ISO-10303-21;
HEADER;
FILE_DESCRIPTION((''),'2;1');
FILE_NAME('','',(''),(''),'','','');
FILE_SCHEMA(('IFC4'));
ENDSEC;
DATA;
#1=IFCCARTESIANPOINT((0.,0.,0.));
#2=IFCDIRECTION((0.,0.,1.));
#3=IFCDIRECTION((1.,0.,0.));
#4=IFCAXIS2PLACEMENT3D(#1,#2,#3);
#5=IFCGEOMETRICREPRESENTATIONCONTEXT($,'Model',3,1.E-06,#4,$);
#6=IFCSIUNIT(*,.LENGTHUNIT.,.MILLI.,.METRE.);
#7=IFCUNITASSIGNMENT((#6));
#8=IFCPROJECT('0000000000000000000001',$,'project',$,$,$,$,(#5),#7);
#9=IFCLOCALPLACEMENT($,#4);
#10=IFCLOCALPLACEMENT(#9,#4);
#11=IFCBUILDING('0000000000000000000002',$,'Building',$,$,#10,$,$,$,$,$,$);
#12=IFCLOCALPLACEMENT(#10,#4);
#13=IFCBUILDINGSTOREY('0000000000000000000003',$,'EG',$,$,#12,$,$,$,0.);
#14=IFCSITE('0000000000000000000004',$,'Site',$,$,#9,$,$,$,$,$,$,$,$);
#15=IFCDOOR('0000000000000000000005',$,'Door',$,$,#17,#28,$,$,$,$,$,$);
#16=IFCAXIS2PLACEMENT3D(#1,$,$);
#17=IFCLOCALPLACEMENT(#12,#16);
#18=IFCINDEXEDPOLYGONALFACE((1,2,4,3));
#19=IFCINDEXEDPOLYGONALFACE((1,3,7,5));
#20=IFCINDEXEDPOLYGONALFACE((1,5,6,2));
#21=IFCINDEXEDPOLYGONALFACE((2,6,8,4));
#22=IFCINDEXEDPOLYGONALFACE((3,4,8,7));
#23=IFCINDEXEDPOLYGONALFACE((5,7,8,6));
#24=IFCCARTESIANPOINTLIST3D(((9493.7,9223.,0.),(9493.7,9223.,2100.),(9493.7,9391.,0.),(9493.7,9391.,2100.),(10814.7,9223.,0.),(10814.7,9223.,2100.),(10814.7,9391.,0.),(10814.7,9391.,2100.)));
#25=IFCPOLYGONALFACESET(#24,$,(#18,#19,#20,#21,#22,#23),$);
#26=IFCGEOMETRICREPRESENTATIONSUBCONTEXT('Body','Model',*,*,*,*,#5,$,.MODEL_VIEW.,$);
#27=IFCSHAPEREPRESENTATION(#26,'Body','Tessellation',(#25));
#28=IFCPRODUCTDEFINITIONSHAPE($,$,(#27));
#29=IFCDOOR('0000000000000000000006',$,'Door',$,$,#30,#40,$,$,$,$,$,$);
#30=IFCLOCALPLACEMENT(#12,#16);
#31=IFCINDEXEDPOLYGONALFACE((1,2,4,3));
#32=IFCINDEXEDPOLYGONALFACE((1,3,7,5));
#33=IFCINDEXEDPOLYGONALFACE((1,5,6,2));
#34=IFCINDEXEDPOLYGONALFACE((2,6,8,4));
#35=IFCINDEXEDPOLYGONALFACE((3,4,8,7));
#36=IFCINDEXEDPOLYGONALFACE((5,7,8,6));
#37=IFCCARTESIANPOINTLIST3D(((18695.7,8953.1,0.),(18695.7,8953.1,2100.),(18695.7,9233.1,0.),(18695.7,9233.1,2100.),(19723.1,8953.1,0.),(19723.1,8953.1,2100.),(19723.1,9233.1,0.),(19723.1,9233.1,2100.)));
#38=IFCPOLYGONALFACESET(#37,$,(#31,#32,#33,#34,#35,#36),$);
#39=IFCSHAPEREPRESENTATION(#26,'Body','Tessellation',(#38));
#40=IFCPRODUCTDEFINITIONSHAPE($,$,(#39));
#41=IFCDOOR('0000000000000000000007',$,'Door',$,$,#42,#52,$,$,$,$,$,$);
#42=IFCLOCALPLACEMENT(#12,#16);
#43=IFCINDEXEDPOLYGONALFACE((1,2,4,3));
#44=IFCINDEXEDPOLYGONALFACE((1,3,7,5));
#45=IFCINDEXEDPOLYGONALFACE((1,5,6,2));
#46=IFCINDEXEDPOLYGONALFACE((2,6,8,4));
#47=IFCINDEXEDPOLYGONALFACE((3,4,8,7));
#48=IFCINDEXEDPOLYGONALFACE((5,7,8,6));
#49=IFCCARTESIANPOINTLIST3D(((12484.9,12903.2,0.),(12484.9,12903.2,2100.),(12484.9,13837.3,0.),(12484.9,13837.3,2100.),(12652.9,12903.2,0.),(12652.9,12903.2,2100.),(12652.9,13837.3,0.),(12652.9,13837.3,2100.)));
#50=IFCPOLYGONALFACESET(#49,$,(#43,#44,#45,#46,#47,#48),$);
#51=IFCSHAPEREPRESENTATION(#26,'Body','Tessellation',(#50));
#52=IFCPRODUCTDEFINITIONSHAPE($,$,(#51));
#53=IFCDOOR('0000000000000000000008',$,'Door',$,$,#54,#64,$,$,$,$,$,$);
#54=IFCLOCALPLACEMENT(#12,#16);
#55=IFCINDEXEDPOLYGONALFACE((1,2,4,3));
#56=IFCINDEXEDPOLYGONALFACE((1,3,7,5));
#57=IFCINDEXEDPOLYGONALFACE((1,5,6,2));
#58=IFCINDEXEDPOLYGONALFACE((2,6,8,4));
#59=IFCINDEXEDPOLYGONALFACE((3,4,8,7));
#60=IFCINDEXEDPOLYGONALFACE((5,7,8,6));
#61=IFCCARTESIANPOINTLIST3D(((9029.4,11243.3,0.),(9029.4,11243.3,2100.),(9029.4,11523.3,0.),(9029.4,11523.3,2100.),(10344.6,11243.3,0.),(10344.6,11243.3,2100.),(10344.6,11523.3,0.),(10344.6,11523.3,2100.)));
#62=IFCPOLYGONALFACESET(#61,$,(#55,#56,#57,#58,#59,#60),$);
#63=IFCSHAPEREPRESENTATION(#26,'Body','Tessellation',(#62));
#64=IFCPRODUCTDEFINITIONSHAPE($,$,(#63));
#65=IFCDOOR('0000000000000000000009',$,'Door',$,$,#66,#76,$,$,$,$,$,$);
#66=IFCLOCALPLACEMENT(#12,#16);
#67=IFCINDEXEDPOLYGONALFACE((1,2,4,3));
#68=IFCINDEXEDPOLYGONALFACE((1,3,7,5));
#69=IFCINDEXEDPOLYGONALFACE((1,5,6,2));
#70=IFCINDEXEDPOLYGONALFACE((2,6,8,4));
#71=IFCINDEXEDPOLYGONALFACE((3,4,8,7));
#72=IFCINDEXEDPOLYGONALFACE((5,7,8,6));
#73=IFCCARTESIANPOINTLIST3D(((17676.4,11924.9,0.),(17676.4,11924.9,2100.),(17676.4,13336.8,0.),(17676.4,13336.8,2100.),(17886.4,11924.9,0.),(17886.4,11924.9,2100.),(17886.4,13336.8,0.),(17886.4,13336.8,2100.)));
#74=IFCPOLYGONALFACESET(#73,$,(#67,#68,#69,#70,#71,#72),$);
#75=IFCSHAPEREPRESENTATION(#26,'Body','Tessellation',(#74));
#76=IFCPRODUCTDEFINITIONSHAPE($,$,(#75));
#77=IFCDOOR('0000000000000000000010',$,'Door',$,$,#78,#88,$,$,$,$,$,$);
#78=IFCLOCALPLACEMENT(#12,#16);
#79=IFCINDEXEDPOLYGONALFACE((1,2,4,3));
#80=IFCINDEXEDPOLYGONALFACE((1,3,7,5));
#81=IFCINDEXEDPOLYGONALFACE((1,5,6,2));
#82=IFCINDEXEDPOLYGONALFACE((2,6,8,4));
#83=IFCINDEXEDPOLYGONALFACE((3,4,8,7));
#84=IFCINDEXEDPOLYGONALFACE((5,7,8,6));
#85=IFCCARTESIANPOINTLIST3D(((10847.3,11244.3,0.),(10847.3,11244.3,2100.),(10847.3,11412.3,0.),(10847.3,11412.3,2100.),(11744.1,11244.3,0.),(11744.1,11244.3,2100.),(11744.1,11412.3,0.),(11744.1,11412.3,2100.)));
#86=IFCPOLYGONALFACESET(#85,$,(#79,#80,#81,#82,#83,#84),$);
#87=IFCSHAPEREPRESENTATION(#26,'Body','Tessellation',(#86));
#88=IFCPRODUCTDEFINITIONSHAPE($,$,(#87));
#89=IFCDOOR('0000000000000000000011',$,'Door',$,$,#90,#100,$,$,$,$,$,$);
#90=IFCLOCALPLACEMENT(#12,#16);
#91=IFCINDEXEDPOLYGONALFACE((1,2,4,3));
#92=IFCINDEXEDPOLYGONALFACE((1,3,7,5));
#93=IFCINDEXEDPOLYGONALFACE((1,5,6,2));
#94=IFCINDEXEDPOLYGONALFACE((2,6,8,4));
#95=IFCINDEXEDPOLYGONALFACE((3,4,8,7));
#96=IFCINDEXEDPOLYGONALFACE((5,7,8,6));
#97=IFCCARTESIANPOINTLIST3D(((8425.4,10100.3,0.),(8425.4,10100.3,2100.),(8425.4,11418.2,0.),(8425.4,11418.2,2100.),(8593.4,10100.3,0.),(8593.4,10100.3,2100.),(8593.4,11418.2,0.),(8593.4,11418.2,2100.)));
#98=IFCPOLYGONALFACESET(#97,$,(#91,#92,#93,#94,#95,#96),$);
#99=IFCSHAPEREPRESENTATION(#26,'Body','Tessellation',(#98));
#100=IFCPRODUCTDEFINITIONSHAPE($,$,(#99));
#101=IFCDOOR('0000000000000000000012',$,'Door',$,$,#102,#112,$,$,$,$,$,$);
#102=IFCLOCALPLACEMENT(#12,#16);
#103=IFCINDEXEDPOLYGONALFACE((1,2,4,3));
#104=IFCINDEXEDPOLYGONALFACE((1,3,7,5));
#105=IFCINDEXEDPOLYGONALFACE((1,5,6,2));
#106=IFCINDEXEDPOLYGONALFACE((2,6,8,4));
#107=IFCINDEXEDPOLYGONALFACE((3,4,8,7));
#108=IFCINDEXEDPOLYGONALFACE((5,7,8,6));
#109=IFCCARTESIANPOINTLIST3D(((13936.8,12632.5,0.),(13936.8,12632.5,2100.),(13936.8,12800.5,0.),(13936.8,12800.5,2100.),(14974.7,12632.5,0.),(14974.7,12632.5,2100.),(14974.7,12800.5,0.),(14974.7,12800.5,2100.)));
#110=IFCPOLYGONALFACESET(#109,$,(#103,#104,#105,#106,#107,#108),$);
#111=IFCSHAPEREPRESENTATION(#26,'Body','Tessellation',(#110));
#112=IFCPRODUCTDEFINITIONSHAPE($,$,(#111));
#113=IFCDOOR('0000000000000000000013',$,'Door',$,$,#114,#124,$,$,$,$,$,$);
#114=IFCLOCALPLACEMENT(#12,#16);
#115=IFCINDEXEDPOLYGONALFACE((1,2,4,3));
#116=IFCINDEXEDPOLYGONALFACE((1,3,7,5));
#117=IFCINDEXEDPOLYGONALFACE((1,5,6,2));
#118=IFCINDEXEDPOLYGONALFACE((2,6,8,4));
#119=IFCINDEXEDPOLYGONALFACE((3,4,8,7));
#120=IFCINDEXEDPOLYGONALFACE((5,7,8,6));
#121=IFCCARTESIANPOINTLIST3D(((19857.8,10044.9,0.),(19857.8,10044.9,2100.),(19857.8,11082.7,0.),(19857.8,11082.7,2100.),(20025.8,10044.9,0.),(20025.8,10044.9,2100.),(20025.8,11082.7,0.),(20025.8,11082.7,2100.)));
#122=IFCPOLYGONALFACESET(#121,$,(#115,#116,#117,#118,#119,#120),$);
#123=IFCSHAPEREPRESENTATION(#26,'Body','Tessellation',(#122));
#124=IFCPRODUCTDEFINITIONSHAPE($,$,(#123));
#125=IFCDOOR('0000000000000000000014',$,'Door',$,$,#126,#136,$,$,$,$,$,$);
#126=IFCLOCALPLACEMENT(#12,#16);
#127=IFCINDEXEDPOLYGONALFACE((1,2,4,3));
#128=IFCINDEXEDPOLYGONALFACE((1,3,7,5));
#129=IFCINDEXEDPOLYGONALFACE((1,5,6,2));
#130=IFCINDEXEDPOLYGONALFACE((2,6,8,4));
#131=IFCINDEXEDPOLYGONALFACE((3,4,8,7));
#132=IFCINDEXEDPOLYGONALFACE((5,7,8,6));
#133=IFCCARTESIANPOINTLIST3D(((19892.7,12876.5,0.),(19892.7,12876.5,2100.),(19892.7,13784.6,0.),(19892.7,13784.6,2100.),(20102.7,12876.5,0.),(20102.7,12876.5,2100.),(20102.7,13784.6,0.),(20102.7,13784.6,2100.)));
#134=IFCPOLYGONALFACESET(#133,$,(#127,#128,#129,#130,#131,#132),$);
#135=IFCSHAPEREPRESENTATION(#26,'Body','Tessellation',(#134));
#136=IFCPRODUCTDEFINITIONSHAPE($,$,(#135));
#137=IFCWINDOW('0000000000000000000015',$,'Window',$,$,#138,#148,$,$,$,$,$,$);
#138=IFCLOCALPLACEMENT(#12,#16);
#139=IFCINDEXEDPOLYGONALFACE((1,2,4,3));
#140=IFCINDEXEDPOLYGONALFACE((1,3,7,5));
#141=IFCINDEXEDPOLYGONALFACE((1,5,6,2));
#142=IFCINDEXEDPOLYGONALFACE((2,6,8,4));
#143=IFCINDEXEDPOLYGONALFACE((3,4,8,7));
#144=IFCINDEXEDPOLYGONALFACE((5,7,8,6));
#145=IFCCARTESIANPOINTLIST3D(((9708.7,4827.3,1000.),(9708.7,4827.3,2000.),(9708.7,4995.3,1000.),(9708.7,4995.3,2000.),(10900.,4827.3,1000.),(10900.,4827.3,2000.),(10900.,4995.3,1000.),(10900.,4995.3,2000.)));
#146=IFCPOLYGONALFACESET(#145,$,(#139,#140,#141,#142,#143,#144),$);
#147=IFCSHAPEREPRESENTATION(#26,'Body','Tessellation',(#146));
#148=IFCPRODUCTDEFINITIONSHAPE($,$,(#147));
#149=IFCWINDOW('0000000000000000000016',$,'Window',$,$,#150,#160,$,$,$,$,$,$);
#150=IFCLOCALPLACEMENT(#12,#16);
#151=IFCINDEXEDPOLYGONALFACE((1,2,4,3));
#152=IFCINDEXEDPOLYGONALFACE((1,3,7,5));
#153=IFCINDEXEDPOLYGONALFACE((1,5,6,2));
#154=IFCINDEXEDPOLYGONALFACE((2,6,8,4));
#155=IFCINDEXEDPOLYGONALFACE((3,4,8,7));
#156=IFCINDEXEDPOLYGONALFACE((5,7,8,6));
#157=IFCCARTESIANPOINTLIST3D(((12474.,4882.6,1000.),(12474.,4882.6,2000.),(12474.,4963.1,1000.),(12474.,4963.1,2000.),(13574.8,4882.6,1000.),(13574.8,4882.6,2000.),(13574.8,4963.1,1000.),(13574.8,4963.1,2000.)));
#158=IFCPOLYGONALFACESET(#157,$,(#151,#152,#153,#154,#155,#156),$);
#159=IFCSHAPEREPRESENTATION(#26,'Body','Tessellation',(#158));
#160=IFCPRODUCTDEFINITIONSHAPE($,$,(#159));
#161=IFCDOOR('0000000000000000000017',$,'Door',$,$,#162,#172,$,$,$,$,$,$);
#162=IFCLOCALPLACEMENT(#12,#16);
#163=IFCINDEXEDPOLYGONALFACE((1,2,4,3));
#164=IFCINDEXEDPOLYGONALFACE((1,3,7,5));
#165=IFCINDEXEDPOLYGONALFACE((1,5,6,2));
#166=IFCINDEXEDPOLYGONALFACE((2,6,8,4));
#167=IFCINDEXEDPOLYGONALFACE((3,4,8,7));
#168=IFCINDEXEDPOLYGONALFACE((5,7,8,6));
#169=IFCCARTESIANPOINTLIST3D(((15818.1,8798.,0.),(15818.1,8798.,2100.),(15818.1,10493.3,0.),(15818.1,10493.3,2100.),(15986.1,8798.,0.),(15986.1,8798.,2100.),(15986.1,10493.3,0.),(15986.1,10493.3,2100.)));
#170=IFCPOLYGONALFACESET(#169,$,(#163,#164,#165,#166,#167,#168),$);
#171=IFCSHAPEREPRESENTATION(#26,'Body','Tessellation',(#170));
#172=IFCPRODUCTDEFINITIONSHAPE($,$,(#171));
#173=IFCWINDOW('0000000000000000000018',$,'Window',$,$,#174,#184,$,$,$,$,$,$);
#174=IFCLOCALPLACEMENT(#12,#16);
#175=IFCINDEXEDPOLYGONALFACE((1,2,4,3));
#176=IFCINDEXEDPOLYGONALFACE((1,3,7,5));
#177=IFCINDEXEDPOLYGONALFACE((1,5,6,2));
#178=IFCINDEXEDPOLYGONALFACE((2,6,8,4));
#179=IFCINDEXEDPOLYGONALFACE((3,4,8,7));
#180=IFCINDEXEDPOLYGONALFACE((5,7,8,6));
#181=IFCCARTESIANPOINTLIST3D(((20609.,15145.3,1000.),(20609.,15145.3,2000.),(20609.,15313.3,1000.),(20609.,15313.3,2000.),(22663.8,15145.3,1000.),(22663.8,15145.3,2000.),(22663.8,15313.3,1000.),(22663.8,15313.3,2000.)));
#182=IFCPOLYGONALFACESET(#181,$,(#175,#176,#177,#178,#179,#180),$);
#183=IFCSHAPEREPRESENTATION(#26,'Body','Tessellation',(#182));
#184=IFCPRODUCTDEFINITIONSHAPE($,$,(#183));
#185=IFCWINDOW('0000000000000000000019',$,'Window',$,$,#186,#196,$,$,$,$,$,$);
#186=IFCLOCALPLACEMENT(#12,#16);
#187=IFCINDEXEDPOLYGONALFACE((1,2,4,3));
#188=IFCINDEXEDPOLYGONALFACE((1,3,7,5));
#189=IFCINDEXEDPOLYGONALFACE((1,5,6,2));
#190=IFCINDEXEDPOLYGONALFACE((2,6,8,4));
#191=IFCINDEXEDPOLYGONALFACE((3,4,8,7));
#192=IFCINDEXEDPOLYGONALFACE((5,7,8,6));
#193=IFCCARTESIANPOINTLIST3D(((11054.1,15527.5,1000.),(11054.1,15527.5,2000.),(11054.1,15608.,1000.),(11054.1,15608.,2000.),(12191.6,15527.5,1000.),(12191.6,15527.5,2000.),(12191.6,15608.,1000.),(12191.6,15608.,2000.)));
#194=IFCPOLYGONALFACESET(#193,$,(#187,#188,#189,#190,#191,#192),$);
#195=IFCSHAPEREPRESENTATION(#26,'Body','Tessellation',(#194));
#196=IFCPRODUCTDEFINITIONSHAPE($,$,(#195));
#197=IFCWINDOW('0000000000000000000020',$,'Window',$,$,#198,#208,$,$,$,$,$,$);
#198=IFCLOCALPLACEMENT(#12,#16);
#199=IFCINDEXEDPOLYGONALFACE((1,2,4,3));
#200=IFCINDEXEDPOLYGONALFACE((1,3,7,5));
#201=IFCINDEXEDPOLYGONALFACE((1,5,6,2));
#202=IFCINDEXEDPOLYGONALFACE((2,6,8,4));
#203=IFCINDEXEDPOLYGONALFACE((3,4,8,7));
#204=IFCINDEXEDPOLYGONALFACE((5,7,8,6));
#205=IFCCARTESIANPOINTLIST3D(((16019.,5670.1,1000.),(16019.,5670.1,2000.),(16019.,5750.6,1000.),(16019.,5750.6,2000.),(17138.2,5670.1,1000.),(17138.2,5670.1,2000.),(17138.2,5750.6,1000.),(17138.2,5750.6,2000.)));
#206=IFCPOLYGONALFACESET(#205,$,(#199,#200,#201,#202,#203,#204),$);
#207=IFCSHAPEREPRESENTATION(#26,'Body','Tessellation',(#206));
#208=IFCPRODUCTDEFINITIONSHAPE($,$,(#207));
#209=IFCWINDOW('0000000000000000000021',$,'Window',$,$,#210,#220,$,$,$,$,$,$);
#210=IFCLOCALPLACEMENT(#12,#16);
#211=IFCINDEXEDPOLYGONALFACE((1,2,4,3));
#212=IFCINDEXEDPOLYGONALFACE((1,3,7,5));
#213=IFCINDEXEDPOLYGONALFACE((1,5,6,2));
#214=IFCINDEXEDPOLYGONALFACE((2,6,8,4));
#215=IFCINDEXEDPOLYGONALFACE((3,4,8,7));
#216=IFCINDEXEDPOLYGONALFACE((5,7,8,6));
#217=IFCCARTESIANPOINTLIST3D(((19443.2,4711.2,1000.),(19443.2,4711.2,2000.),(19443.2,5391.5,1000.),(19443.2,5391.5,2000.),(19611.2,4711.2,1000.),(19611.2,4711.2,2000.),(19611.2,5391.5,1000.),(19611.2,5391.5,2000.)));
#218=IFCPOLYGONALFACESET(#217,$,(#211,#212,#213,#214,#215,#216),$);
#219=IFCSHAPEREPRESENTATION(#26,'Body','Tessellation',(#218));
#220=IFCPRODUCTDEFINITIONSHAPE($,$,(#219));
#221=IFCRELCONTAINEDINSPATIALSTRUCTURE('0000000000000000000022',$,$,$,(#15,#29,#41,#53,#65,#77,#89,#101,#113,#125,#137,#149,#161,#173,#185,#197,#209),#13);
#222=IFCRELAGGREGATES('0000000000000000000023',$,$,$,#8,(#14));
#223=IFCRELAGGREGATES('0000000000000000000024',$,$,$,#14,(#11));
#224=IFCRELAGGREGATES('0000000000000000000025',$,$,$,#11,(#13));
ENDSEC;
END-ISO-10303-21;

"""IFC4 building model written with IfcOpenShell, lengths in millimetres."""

from ifc_helpers import new_model, si_unit, frame, origin_with_axes, place, context, subcontext, project, spatial, rectangle, extrude, element, save


model = new_model("IFC4")

# Units and contexts
model_context = context("Model", 3, precision=1e-06, world=origin_with_axes())
body_context = subcontext(model_context, "Body", "Model", "MODEL_VIEW")
ifc_project = project(units=[si_unit("LENGTHUNIT", "METRE", prefix="MILLI")], contexts=[model_context])

# Site, building, storey
site_placement = place(None, origin_with_axes())
site = spatial("IfcSite", under=ifc_project, at=site_placement, Name="Site")
building_placement = place(site_placement, origin_with_axes())
building = spatial("IfcBuilding", under=site, at=building_placement, Name="Building")
storey_placement = place(building_placement, origin_with_axes())
storey = spatial("IfcBuildingStorey", under=building, at=storey_placement, Name="EG", Elevation=0.0)

# Doors
door_1_placement = place(storey_placement, origin_with_axes())
element("IfcDoor", 1, at=door_1_placement, inside=storey, Name="Door", context=body_context, shape_type="SweptSolid", body=[
    extrude(rectangle(XDim=1321.0, YDim=168.0), frame((10154.2, 9307.0, 0.0), z_axis=(0.0, 0.0, 1.0), x_axis=(1.0, 0.0, 0.0)), (0.0, 0.0, 1.0), 2100.0),
])
door_2_placement = place(storey_placement, origin_with_axes())
element("IfcDoor", 2, at=door_2_placement, inside=storey, Name="Door", context=body_context, shape_type="SweptSolid", body=[
    extrude(rectangle(XDim=1027.4, YDim=280.0), frame((19209.4, 9093.1, 0.0), z_axis=(0.0, 0.0, 1.0), x_axis=(1.0, 0.0, 0.0)), (0.0, 0.0, 1.0), 2100.0),
])
door_3_placement = place(storey_placement, origin_with_axes())
element("IfcDoor", 3, at=door_3_placement, inside=storey, Name="Door", context=body_context, shape_type="SweptSolid", body=[
    extrude(rectangle(XDim=934.1, YDim=168.0), frame((12568.9, 13370.2, 0.0), z_axis=(0.0, 0.0, 1.0), x_axis=(0.0, 1.0, 0.0)), (0.0, 0.0, 1.0), 2100.0),
])
door_4_placement = place(storey_placement, origin_with_axes())
element("IfcDoor", 4, at=door_4_placement, inside=storey, Name="Door", context=body_context, shape_type="SweptSolid", body=[
    extrude(rectangle(XDim=1315.2, YDim=280.0), frame((9687.0, 11383.3, 0.0), z_axis=(0.0, 0.0, 1.0), x_axis=(1.0, 0.0, 0.0)), (0.0, 0.0, 1.0), 2100.0),
])
door_5_placement = place(storey_placement, origin_with_axes())
element("IfcDoor", 5, at=door_5_placement, inside=storey, Name="Door", context=body_context, shape_type="SweptSolid", body=[
    extrude(rectangle(XDim=1411.9, YDim=210.0), frame((17781.4, 12630.8, 0.0), z_axis=(0.0, 0.0, 1.0), x_axis=(0.0, 1.0, 0.0)), (0.0, 0.0, 1.0), 2100.0),
])
door_6_placement = place(storey_placement, origin_with_axes())
element("IfcDoor", 6, at=door_6_placement, inside=storey, Name="Door", context=body_context, shape_type="SweptSolid", body=[
    extrude(rectangle(XDim=896.8, YDim=168.0), frame((11295.7, 11328.3, 0.0), z_axis=(0.0, 0.0, 1.0), x_axis=(1.0, 0.0, 0.0)), (0.0, 0.0, 1.0), 2100.0),
])
door_7_placement = place(storey_placement, origin_with_axes())
element("IfcDoor", 7, at=door_7_placement, inside=storey, Name="Door", context=body_context, shape_type="SweptSolid", body=[
    extrude(rectangle(XDim=1317.9, YDim=168.0), frame((8509.4, 10759.2, 0.0), z_axis=(0.0, 0.0, 1.0), x_axis=(0.0, 1.0, 0.0)), (0.0, 0.0, 1.0), 2100.0),
])
door_8_placement = place(storey_placement, origin_with_axes())
element("IfcDoor", 8, at=door_8_placement, inside=storey, Name="Door", context=body_context, shape_type="SweptSolid", body=[
    extrude(rectangle(XDim=1037.8, YDim=168.0), frame((14455.7, 12716.5, 0.0), z_axis=(0.0, 0.0, 1.0), x_axis=(1.0, 0.0, 0.0)), (0.0, 0.0, 1.0), 2100.0),
])
door_9_placement = place(storey_placement, origin_with_axes())
element("IfcDoor", 9, at=door_9_placement, inside=storey, Name="Door", context=body_context, shape_type="SweptSolid", body=[
    extrude(rectangle(XDim=1037.8, YDim=168.0), frame((19941.8, 10563.8, 0.0), z_axis=(0.0, 0.0, 1.0), x_axis=(0.0, 1.0, 0.0)), (0.0, 0.0, 1.0), 2100.0),
])
door_10_placement = place(storey_placement, origin_with_axes())
element("IfcDoor", 10, at=door_10_placement, inside=storey, Name="Door", context=body_context, shape_type="SweptSolid", body=[
    extrude(rectangle(XDim=908.1, YDim=210.0), frame((19997.7, 13330.5, 0.0), z_axis=(0.0, 0.0, 1.0), x_axis=(0.0, 1.0, 0.0)), (0.0, 0.0, 1.0), 2100.0),
])

# Windows
window_1_placement = place(storey_placement, origin_with_axes())
element("IfcWindow", 11, at=window_1_placement, inside=storey, Name="Window", context=body_context, shape_type="SweptSolid", body=[
    extrude(rectangle(XDim=1191.3, YDim=168.0), frame((10304.4, 4911.3, 1000.0), z_axis=(0.0, 0.0, 1.0), x_axis=(1.0, 0.0, 0.0)), (0.0, 0.0, 1.0), 1000.0),
])
window_2_placement = place(storey_placement, origin_with_axes())
element("IfcWindow", 12, at=window_2_placement, inside=storey, Name="Window", context=body_context, shape_type="SweptSolid", body=[
    extrude(rectangle(XDim=1100.8, YDim=80.5), frame((13024.4, 4922.9, 1000.0), z_axis=(0.0, 0.0, 1.0), x_axis=(1.0, 0.0, 0.0)), (0.0, 0.0, 1.0), 1000.0),
])

# Door
door_11_placement = place(storey_placement, origin_with_axes())
element("IfcDoor", 13, at=door_11_placement, inside=storey, Name="Door", context=body_context, shape_type="SweptSolid", body=[
    extrude(rectangle(XDim=1695.3, YDim=168.0), frame((15902.1, 9645.7, 0.0), z_axis=(0.0, 0.0, 1.0), x_axis=(0.0, 1.0, 0.0)), (0.0, 0.0, 1.0), 2100.0),
])

# Windows
window_3_placement = place(storey_placement, origin_with_axes())
element("IfcWindow", 14, at=window_3_placement, inside=storey, Name="Window", context=body_context, shape_type="SweptSolid", body=[
    extrude(rectangle(XDim=2054.8, YDim=168.0), frame((21636.4, 15229.3, 1000.0), z_axis=(0.0, 0.0, 1.0), x_axis=(1.0, 0.0, 0.0)), (0.0, 0.0, 1.0), 1000.0),
])
window_4_placement = place(storey_placement, origin_with_axes())
element("IfcWindow", 15, at=window_4_placement, inside=storey, Name="Window", context=body_context, shape_type="SweptSolid", body=[
    extrude(rectangle(XDim=1137.5, YDim=80.5), frame((11622.8, 15567.7, 1000.0), z_axis=(0.0, 0.0, 1.0), x_axis=(1.0, 0.0, 0.0)), (0.0, 0.0, 1.0), 1000.0),
])
window_5_placement = place(storey_placement, origin_with_axes())
element("IfcWindow", 16, at=window_5_placement, inside=storey, Name="Window", context=body_context, shape_type="SweptSolid", body=[
    extrude(rectangle(XDim=1119.1, YDim=80.5), frame((16578.6, 5710.3, 1000.0), z_axis=(0.0, 0.0, 1.0), x_axis=(1.0, 0.0, 0.0)), (0.0, 0.0, 1.0), 1000.0),
])
window_6_placement = place(storey_placement, origin_with_axes())
element("IfcWindow", 17, at=window_6_placement, inside=storey, Name="Window", context=body_context, shape_type="SweptSolid", body=[
    extrude(rectangle(XDim=680.2, YDim=168.0), frame((19527.2, 5051.4, 1000.0), z_axis=(0.0, 0.0, 1.0), x_axis=(0.0, 1.0, 0.0)), (0.0, 0.0, 1.0), 1000.0),
])

save(model, "model.ifc")
